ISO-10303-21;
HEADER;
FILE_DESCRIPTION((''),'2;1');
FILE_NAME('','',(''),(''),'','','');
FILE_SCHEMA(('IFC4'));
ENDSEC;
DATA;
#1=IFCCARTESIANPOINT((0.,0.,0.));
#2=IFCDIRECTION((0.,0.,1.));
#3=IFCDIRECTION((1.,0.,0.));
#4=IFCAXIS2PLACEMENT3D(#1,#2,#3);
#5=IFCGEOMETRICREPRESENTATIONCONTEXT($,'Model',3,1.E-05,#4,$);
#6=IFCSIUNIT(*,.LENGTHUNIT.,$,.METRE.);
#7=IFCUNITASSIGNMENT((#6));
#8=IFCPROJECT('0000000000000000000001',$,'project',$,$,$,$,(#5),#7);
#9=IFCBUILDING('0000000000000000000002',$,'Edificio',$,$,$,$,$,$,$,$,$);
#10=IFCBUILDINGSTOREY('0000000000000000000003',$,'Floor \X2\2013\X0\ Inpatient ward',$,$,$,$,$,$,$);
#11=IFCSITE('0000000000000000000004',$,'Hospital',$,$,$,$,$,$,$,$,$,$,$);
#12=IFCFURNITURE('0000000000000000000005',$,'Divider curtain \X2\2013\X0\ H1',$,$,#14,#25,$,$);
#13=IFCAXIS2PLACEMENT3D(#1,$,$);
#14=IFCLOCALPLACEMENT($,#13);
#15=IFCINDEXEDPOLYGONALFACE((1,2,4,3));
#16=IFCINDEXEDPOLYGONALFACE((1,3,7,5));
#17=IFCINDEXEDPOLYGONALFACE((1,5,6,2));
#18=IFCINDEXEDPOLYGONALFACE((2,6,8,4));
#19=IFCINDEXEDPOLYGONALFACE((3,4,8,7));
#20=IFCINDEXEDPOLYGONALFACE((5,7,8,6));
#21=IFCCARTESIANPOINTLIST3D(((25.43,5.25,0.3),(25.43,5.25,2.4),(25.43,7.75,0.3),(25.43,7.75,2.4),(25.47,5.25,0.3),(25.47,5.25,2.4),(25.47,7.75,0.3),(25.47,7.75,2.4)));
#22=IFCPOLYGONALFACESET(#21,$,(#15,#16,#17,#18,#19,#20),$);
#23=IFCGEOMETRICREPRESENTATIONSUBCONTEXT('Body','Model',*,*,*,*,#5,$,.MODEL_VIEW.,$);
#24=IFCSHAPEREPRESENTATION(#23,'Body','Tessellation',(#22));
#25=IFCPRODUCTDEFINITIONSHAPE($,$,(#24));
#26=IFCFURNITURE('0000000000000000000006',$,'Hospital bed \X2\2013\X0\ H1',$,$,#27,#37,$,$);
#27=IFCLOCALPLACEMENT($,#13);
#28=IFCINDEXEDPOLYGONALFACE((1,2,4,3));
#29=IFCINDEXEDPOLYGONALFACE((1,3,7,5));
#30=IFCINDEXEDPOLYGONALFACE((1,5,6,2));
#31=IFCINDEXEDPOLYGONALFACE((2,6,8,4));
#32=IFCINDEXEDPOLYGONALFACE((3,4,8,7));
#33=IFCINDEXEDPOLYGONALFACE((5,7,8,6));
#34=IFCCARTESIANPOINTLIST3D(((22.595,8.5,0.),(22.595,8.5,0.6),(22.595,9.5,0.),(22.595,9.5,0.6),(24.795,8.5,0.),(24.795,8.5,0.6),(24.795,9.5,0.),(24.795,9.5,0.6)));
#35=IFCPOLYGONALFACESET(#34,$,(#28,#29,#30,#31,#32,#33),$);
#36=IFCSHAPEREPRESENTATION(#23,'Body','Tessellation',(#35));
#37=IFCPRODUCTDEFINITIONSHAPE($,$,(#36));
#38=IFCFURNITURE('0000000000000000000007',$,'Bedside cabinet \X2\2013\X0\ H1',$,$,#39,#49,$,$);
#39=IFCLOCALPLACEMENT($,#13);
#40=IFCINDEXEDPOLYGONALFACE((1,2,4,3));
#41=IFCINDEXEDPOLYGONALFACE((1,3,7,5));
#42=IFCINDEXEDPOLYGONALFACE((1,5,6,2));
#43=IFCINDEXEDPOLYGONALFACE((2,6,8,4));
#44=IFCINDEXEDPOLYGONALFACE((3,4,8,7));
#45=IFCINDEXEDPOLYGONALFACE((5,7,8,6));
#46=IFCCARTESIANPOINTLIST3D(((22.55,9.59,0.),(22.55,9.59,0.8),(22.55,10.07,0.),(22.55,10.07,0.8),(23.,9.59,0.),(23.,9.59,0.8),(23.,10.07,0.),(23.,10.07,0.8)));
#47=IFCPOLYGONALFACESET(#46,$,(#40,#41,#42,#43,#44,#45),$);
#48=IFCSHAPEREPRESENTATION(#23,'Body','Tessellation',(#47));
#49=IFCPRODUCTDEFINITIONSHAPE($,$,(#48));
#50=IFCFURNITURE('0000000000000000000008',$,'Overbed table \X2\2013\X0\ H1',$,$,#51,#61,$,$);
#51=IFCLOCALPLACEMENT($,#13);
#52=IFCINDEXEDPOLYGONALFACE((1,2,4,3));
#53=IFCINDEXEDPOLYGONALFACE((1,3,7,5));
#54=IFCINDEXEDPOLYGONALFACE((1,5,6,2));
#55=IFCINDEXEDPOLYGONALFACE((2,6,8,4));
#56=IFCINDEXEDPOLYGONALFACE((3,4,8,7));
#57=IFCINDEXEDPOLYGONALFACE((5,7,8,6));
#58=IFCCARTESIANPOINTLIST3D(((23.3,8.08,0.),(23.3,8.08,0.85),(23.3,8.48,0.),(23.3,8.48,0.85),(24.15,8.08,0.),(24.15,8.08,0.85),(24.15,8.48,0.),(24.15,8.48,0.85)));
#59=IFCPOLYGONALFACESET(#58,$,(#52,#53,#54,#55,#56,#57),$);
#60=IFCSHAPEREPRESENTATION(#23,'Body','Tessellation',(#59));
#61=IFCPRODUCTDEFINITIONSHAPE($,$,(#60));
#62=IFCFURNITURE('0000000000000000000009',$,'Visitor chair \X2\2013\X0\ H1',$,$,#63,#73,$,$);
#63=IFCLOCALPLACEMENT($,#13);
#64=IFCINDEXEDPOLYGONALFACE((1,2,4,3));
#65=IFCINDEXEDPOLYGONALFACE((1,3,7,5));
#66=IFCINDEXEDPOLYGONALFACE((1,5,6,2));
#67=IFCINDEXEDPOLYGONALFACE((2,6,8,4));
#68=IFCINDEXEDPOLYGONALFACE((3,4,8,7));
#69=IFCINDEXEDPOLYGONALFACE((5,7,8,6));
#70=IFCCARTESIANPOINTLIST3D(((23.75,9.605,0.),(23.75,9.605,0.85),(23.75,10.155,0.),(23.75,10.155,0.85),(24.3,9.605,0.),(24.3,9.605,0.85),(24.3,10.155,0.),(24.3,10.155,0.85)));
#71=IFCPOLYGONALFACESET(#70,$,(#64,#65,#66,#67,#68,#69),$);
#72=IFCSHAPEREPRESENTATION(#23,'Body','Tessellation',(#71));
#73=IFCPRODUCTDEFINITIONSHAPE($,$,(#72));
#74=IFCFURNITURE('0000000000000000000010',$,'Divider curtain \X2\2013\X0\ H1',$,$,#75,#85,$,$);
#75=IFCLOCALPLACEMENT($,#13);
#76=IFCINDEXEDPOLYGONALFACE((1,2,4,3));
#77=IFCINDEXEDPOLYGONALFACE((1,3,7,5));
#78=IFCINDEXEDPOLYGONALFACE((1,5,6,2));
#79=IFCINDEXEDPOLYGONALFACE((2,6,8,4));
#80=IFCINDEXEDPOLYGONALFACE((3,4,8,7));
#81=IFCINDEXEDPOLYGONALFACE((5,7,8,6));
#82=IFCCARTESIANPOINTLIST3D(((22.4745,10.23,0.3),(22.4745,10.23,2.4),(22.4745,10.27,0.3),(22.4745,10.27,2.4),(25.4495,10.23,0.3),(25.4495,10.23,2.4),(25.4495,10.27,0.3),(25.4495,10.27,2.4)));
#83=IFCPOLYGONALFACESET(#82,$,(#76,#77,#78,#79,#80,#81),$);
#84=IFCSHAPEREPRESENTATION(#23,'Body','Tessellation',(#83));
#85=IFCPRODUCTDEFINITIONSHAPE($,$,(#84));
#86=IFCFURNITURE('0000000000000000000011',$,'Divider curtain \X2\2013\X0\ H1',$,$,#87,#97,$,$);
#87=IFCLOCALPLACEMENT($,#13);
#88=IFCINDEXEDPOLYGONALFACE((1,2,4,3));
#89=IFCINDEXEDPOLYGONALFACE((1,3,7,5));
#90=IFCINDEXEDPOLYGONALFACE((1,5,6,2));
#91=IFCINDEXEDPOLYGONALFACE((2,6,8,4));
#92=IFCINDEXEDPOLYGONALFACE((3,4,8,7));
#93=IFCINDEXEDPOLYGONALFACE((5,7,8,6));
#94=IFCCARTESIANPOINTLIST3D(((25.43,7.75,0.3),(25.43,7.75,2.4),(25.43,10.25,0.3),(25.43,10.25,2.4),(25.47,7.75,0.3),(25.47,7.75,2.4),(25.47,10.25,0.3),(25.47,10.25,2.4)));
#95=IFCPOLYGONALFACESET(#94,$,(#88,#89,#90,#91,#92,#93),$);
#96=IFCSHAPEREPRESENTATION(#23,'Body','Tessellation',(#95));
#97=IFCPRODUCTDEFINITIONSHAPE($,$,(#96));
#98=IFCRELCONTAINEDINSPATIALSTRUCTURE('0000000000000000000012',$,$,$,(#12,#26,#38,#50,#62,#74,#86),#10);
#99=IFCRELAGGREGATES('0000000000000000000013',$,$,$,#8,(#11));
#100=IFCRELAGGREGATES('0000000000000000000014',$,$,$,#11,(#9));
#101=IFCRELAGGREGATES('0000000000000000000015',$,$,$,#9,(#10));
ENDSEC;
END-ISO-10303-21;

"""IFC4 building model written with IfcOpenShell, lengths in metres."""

from ifc_helpers import new_model, si_unit, frame, origin_with_axes, context, subcontext, project, spatial, line, indexed_curve, outline, extrude, element, save


model = new_model("IFC4")

# Units and contexts
model_context = context("Model", 3, precision=1e-05, world=origin_with_axes())
body_context = subcontext(model_context, "Body", "Model", "MODEL_VIEW")
ifc_project = project(units=[si_unit("LENGTHUNIT", "METRE")], contexts=[model_context])

# Site, building, storey
site = spatial("IfcSite", under=ifc_project, Name="Hospital")
building = spatial("IfcBuilding", under=site, Name="Edificio")
storey = spatial("IfcBuildingStorey", under=building, Name="Floor – Inpatient ward")

# Furniture
element("IfcFurniture", 1, inside=storey, Name="Divider curtain – H1", context=body_context, shape_type="SweptSolid", body=[
    extrude(outline(indexed_curve([(0.0, 0.0), (0.04, 0.0), (0.04, 2.5), (0.0, 2.5)], segments=[line(1, 2, 3, 4, 1)])), frame((25.43, 5.25, 0.3), z_axis=(0.0, 0.0, 1.0), x_axis=(1.0, 0.0, 0.0)), (0.0, 0.0, 1.0), 2.1),
])
element("IfcFurniture", 2, inside=storey, Name="Hospital bed – H1", context=body_context, shape_type="SweptSolid", body=[
    extrude(outline(indexed_curve([(0.0, 0.0), (2.2, 0.0), (2.2, 1.0), (0.0, 1.0)], segments=[line(1, 2, 3, 4, 1)])), frame((22.595, 8.5, 0.0), z_axis=(0.0, 0.0, 1.0), x_axis=(1.0, 0.0, 0.0)), (0.0, 0.0, 1.0), 0.6),
])
element("IfcFurniture", 3, inside=storey, Name="Bedside cabinet – H1", context=body_context, shape_type="SweptSolid", body=[
    extrude(outline(indexed_curve([(0.0, 0.0), (0.45, 0.0), (0.45, 0.48), (0.0, 0.48)], segments=[line(1, 2, 3, 4, 1)])), frame((22.55, 9.59, 0.0), z_axis=(0.0, 0.0, 1.0), x_axis=(1.0, 0.0, 0.0)), (0.0, 0.0, 1.0), 0.8),
])
element("IfcFurniture", 4, inside=storey, Name="Overbed table – H1", context=body_context, shape_type="SweptSolid", body=[
    extrude(outline(indexed_curve([(0.0, 0.0), (0.85, 0.0), (0.85, 0.4), (0.0, 0.4)], segments=[line(1, 2, 3, 4, 1)])), frame((23.3, 8.08, 0.0), z_axis=(0.0, 0.0, 1.0), x_axis=(1.0, 0.0, 0.0)), (0.0, 0.0, 1.0), 0.85),
])
element("IfcFurniture", 5, inside=storey, Name="Visitor chair – H1", context=body_context, shape_type="SweptSolid", body=[
    extrude(outline(indexed_curve([(0.0, 0.0), (0.55, 0.0), (0.55, 0.55), (0.0, 0.55)], segments=[line(1, 2, 3, 4, 1)])), frame((23.75, 9.605, 0.0), z_axis=(0.0, 0.0, 1.0), x_axis=(1.0, 0.0, 0.0)), (0.0, 0.0, 1.0), 0.85),
])
element("IfcFurniture", 6, inside=storey, Name="Divider curtain – H1", context=body_context, shape_type="SweptSolid", body=[
    extrude(outline(indexed_curve([(0.0, 0.0), (2.975, 0.0), (2.975, 0.04), (0.0, 0.04)], segments=[line(1, 2, 3, 4, 1)])), frame((22.4745, 10.23, 0.3), z_axis=(0.0, 0.0, 1.0), x_axis=(1.0, 0.0, 0.0)), (0.0, 0.0, 1.0), 2.1),
])
element("IfcFurniture", 7, inside=storey, Name="Divider curtain – H1", context=body_context, shape_type="SweptSolid", body=[
    extrude(outline(indexed_curve([(0.0, 0.0), (0.04, 0.0), (0.04, 2.5), (0.0, 2.5)], segments=[line(1, 2, 3, 4, 1)])), frame((25.43, 7.75, 0.3), z_axis=(0.0, 0.0, 1.0), x_axis=(1.0, 0.0, 0.0)), (0.0, 0.0, 1.0), 2.1),
])

save(model, "model.ifc")
